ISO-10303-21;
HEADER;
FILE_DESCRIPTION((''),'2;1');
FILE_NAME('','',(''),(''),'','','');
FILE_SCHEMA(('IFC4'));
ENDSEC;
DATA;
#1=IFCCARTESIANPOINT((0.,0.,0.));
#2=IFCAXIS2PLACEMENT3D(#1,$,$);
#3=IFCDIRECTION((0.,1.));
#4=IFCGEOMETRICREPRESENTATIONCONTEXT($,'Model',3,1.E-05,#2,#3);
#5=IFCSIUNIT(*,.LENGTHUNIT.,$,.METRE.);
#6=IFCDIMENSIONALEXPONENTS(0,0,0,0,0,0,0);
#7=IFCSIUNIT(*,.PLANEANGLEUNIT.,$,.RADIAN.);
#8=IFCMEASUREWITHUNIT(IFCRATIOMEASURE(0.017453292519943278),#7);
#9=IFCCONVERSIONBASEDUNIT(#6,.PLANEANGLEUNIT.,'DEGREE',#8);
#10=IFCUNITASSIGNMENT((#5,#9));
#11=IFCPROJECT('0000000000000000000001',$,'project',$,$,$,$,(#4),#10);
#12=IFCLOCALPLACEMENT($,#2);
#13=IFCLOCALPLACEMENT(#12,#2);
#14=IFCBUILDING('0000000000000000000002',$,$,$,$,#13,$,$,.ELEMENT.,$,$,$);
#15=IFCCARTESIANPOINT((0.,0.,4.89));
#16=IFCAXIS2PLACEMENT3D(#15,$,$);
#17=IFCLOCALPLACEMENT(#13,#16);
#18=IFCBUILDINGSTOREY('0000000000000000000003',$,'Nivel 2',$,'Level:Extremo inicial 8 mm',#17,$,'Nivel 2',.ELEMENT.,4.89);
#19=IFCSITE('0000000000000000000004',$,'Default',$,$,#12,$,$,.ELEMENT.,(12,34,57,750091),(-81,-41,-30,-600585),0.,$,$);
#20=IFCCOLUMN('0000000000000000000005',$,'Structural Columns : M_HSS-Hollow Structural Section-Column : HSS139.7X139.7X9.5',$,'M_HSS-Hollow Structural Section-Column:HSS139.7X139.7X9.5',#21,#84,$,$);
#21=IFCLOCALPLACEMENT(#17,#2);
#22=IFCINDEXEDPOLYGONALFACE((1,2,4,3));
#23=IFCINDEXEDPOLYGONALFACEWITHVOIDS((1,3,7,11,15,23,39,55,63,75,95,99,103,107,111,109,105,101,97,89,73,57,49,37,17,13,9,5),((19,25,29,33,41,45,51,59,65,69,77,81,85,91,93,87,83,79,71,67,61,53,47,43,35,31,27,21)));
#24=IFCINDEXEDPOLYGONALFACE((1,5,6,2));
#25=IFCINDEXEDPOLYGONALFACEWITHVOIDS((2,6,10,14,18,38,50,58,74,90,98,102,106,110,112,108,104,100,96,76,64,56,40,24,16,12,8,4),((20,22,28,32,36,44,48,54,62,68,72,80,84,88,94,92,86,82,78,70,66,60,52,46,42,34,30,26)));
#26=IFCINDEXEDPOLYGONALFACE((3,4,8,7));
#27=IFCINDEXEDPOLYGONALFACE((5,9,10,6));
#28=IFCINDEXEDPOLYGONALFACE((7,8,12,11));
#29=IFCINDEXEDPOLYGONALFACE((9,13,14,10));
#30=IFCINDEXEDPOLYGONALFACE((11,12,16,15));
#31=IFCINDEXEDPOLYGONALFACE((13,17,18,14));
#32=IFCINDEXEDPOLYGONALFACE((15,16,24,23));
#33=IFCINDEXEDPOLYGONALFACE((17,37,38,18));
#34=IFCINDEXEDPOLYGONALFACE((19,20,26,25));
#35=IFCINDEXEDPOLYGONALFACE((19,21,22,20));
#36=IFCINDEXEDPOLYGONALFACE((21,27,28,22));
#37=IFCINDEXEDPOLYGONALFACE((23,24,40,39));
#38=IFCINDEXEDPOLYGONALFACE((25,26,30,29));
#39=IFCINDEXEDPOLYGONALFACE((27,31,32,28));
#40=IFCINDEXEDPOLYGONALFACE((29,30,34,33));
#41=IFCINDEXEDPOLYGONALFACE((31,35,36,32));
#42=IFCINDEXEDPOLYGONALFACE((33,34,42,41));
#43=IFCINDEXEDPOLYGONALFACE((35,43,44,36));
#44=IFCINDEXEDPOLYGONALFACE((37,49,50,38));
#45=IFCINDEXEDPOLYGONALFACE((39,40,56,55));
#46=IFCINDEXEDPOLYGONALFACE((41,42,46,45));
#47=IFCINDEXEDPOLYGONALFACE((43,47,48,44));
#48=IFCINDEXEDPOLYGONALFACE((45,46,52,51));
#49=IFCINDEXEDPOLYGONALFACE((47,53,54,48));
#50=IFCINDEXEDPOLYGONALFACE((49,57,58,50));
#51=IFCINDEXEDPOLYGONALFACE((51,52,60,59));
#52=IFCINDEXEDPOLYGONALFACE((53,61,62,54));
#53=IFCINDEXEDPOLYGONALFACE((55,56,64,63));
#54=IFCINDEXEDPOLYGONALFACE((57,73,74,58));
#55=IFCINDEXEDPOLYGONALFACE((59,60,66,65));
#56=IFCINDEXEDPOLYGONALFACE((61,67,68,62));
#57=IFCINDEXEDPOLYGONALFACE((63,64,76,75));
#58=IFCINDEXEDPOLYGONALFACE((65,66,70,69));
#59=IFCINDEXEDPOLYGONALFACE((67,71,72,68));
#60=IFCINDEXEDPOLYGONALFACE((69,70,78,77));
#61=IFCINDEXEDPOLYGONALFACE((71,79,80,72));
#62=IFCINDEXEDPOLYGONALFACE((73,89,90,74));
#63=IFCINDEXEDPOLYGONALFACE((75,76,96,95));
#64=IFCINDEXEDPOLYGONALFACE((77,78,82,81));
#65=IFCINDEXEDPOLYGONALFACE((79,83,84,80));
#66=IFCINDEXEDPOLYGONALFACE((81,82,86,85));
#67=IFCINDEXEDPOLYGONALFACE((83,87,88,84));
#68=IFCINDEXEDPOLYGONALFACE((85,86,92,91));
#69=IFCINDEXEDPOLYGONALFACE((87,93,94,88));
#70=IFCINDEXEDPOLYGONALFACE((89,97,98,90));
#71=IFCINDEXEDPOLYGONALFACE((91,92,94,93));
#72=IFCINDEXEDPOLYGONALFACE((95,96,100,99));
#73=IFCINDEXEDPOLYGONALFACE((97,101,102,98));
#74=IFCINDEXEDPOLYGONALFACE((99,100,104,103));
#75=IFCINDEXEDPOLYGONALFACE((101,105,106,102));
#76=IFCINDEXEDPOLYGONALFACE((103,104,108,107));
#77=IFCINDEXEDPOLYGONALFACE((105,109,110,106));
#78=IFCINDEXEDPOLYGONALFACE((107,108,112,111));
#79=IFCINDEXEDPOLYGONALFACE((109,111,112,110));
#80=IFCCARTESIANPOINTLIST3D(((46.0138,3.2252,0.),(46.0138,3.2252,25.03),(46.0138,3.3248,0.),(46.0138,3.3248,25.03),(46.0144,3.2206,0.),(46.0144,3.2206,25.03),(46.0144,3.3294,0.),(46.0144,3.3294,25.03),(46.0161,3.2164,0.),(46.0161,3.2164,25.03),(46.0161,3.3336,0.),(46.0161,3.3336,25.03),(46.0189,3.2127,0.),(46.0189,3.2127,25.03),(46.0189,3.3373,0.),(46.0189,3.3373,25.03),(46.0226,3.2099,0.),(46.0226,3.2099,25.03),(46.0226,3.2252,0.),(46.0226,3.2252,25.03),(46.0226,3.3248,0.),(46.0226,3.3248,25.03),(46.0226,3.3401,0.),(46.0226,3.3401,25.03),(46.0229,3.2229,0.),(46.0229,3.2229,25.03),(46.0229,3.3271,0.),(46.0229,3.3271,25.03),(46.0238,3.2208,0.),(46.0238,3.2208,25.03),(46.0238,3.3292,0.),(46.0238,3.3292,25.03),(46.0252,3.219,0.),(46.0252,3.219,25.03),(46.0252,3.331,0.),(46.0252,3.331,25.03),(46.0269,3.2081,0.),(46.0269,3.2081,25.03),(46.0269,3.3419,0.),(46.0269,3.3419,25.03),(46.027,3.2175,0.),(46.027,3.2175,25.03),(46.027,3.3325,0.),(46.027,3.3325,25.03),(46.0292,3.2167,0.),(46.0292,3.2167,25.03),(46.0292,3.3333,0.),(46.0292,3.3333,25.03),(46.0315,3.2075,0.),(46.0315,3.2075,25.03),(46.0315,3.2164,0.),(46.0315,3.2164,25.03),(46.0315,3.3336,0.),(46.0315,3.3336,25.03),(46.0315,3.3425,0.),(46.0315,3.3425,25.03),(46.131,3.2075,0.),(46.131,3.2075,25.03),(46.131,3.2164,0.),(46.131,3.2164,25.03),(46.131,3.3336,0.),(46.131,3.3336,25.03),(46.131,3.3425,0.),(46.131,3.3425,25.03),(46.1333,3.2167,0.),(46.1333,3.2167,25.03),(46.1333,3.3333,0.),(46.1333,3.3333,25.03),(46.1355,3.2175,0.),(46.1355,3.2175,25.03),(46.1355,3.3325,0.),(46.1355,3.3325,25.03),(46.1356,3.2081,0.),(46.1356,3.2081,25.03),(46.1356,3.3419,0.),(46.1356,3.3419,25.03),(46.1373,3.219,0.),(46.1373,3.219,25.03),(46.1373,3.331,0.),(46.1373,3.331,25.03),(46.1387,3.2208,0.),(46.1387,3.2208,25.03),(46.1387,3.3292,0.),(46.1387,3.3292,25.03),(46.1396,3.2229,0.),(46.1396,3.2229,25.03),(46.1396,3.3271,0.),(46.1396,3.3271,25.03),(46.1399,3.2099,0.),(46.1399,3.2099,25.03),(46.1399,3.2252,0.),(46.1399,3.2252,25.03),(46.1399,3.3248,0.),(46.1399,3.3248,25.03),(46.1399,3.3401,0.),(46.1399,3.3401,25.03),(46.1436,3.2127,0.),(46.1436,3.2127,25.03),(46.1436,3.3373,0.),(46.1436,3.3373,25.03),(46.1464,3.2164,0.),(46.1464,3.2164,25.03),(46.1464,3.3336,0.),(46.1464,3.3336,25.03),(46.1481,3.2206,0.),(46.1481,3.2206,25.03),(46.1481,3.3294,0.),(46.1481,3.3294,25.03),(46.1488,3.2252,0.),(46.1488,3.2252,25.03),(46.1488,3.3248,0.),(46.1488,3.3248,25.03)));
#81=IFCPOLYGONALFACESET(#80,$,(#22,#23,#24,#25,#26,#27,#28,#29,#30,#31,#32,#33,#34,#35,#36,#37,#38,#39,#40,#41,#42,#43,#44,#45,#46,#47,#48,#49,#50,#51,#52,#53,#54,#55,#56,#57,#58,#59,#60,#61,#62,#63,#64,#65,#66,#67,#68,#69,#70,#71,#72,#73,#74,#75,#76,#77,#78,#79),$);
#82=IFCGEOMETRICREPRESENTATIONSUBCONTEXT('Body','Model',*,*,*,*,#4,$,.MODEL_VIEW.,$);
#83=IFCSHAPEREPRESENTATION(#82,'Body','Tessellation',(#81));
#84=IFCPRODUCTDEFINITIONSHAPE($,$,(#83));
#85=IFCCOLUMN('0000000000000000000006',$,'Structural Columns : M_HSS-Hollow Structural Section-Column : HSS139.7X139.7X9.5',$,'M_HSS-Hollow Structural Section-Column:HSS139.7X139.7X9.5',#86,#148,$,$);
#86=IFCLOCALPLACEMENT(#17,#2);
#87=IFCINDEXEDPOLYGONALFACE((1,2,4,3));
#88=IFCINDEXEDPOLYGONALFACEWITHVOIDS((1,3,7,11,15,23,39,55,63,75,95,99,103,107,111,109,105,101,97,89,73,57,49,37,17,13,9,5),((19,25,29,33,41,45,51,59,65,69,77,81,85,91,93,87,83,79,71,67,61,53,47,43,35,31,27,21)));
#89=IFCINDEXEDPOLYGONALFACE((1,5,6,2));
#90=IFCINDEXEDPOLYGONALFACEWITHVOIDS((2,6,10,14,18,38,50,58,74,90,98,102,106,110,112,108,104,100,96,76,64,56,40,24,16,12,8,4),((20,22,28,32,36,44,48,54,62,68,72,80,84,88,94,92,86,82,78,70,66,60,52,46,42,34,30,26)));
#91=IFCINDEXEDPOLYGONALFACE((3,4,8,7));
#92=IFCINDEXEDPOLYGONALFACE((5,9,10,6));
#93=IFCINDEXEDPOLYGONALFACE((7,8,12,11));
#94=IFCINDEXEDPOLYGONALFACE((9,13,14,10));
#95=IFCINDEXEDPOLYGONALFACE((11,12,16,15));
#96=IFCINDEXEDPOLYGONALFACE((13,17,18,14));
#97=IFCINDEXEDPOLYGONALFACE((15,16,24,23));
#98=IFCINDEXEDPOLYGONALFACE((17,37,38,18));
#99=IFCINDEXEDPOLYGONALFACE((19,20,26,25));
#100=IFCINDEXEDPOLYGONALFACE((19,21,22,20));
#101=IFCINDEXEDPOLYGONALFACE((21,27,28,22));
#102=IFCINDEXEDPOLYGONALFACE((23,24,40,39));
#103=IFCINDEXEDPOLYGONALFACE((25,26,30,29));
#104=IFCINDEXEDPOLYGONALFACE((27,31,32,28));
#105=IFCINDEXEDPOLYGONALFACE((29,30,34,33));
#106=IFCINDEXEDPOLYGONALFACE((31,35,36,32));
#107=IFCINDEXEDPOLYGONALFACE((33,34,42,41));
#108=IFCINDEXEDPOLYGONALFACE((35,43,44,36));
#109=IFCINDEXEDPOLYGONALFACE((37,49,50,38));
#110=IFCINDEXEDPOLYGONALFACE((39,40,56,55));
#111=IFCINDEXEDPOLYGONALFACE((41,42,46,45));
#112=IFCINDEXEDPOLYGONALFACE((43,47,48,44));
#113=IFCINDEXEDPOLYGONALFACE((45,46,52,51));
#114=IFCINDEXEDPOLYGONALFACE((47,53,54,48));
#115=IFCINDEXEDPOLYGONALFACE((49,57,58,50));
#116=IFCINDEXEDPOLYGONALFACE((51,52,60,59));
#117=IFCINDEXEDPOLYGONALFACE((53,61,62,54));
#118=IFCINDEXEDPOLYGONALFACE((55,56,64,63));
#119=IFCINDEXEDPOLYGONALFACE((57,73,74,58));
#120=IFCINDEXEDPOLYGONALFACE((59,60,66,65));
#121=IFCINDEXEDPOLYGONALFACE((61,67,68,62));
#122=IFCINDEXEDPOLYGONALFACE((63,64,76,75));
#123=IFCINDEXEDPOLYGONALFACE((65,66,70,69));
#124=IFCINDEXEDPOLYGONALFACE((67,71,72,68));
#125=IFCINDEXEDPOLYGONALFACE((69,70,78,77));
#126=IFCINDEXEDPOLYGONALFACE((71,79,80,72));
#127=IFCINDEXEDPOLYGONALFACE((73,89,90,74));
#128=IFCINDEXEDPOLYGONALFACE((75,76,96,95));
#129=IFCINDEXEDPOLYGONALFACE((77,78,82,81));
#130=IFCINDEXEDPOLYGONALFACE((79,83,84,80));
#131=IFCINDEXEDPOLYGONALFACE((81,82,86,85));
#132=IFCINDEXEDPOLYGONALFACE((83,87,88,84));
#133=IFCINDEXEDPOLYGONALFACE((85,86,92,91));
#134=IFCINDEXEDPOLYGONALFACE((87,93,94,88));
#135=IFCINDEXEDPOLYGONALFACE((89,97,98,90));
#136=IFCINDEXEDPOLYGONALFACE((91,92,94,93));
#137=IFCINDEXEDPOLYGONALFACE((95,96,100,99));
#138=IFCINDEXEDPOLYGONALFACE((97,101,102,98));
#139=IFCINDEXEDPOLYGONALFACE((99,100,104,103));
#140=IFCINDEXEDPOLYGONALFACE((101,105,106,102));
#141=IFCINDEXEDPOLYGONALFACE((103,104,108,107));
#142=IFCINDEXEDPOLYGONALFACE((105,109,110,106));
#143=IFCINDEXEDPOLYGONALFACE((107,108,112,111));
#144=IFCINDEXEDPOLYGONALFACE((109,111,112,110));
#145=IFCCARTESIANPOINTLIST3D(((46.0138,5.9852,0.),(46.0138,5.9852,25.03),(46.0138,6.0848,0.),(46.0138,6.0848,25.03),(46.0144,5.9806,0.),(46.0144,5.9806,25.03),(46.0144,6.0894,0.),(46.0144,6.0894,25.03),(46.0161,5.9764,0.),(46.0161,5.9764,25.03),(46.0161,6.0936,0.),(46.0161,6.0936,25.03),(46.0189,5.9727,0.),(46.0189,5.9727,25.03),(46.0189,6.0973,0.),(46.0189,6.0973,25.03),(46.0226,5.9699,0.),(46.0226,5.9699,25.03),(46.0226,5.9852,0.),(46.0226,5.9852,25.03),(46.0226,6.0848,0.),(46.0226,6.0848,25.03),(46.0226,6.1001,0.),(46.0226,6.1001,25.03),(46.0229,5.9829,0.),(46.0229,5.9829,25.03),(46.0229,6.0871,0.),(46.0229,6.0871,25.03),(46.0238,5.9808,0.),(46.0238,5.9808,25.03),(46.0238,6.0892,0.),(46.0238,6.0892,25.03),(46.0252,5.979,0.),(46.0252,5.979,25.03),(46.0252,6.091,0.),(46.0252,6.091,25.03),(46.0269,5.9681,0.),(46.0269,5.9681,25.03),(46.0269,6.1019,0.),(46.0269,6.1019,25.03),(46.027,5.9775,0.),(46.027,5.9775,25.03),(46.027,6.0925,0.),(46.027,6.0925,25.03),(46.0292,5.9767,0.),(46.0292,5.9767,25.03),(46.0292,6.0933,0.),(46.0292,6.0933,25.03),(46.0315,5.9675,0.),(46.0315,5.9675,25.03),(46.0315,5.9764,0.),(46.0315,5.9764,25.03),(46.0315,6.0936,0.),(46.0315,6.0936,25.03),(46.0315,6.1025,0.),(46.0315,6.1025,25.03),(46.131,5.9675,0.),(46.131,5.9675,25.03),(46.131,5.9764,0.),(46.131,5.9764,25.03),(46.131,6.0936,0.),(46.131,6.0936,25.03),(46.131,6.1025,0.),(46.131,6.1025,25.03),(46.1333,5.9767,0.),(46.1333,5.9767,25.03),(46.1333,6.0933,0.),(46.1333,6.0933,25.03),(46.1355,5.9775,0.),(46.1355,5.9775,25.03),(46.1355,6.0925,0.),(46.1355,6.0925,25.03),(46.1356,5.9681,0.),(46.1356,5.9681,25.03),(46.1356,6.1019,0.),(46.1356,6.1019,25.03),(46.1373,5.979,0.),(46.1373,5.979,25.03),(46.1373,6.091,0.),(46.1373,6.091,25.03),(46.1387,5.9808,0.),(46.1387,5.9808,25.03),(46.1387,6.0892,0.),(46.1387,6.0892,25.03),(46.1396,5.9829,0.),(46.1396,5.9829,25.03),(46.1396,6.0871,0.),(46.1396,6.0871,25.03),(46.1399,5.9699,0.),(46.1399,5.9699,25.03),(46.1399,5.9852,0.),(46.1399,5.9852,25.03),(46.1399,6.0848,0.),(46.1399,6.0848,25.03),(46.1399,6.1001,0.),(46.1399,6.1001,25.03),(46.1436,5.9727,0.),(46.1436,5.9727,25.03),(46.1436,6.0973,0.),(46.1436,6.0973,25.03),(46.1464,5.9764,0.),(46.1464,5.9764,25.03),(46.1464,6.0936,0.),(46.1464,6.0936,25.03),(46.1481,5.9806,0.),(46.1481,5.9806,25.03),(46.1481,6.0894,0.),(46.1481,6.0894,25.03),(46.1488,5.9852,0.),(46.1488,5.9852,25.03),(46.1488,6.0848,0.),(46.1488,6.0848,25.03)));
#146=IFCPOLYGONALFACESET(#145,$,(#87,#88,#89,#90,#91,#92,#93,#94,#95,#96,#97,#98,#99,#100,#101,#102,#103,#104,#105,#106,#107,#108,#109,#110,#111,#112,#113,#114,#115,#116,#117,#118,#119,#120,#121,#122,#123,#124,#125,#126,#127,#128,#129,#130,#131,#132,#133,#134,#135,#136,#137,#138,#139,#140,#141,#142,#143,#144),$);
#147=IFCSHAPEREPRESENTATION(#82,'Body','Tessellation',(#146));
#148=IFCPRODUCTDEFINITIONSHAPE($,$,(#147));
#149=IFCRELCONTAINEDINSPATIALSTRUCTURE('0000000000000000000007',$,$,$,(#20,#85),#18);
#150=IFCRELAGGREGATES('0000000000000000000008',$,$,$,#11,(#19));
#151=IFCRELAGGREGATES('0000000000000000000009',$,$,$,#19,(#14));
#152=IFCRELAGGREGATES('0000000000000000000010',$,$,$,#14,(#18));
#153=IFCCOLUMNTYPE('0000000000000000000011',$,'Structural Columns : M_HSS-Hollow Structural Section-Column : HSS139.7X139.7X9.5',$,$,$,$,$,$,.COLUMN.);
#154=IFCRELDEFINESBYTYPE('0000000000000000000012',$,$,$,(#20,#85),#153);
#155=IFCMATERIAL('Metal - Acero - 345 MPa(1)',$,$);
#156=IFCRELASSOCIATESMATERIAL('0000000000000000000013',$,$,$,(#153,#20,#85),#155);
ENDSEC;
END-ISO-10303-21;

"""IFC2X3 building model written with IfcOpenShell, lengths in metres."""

from ifc_helpers import new_model, entity, si_unit, converted_unit, direction, frame, frame_2d, origin, place, context, subcontext, project, spatial, polyline, circle_curve, parameter, trimmed, segment, composite_curve, outline, extrude, source, transform, mapped, material, type_object, type_shapes, element, save


model = new_model("IFC2X3")

# Units and contexts
model_context = context("Model", 3, precision=1e-05, world=origin(), true_north=direction((0.0, 1.0)))
body_context = subcontext(model_context, "Body", "Model", "MODEL_VIEW")
ifc_project = project(units=[si_unit("LENGTHUNIT", "METRE"), converted_unit("PLANEANGLEUNIT", "DEGREE", entity("IfcRatioMeasure", 0.017453292519943278), si_unit("PLANEANGLEUNIT", "RADIAN"), dimensions=[0, 0, 0, 0, 0, 0, 0])], contexts=[model_context])

# Site, building, storey
site_placement = place(None, origin())
site = spatial("IfcSite", under=ifc_project, at=site_placement, Name="Default", CompositionType="ELEMENT", RefLatitude=(12, 34, 57, 750091), RefLongitude=(-81, -41, -30, -600585), RefElevation=0.0)
building_placement = place(site_placement, origin())
building = spatial("IfcBuilding", under=site, at=building_placement, CompositionType="ELEMENT")
storey_placement = place(building_placement, frame((0.0, 0.0, 4.89)))
storey = spatial("IfcBuildingStorey", under=building, at=storey_placement, Name="Nivel 2", ObjectType="Level:Extremo inicial 8 mm", LongName="Nivel 2", CompositionType="ELEMENT", Elevation=4.89)

# Columns
ifc_material_1 = material(Name="Metal - Acero - 345 MPa(1)")
column_type_1 = type_object("IfcColumnType", Name="Structural Columns : M_HSS-Hollow Structural Section-Column : HSS139.7X139.7X9.5", PredefinedType="COLUMN", material=ifc_material_1)
shared_shape_1 = source(origin(), body_context, "Body", "SweptSolid", [
    extrude(outline(composite_curve([segment(polyline([(-0.0498, -0.0675), (0.0498, -0.0675)]), True, "CONTINUOUS"), segment(trimmed(circle_curve(frame_2d((0.0498, -0.0498), x_axis=(-1.0, 0.0)), 0.0177), [parameter(90.0)], [parameter(180.0)], True, "PARAMETER"), True, "CONTINUOUS"), segment(polyline([(0.0675, -0.0498), (0.0675, 0.0498)]), True, "CONTINUOUS"), segment(trimmed(circle_curve(frame_2d((0.0498, 0.0498), x_axis=(-1.0, 0.0)), 0.0177), [parameter(180.0)], [parameter(270.0)], True, "PARAMETER"), True, "CONTINUOUS"), segment(polyline([(0.0498, 0.0675), (-0.0498, 0.0675)]), True, "CONTINUOUS"), segment(trimmed(circle_curve(frame_2d((-0.0498, 0.0498), x_axis=(-1.0, 0.0)), 0.0177), [parameter(270.0)], [parameter(360.0)], True, "PARAMETER"), True, "CONTINUOUS"), segment(polyline([(-0.0675, 0.0498), (-0.0675, -0.0498)]), True, "CONTINUOUS"), segment(trimmed(circle_curve(frame_2d((-0.0498, -0.0498), x_axis=(-1.0, 0.0)), 0.0177), [parameter(360.0)], [parameter(90.0)], True, "PARAMETER"), True, "CONTINUOUS")], self_intersect=False), holes=[composite_curve([segment(trimmed(circle_curve(frame_2d((-0.0498, -0.0498), x_axis=(-1.0, 0.0)), 0.0089), [parameter(0.0)], [parameter(90.0)], True, "PARAMETER"), False, "CONTINUOUS"), segment(polyline([(-0.0586, -0.0498), (-0.0586, 0.0498)]), True, "CONTINUOUS"), segment(trimmed(circle_curve(frame_2d((-0.0498, 0.0498), x_axis=(-1.0, 0.0)), 0.0089), [parameter(270.0)], [parameter(0.0)], True, "PARAMETER"), False, "CONTINUOUS"), segment(polyline([(-0.0498, 0.0586), (0.0498, 0.0586)]), True, "CONTINUOUS"), segment(trimmed(circle_curve(frame_2d((0.0498, 0.0498), x_axis=(-1.0, 0.0)), 0.0089), [parameter(180.0)], [parameter(270.0)], True, "PARAMETER"), False, "CONTINUOUS"), segment(polyline([(0.0586, 0.0498), (0.0586, -0.0498)]), True, "CONTINUOUS"), segment(trimmed(circle_curve(frame_2d((0.0498, -0.0498), x_axis=(-1.0, 0.0)), 0.0089), [parameter(90.0)], [parameter(180.0)], True, "PARAMETER"), False, "CONTINUOUS"), segment(polyline([(0.0498, -0.0586), (-0.0498, -0.0586)]), True, "CONTINUOUS")], self_intersect=False)]), frame((0.0, 0.0, 4.89), z_axis=(0.0, 0.0, 1.0), x_axis=(-1.0, 0.0, 0.0)), (0.0, 0.0, 1.0), 25.03),
])
type_shapes(column_type_1, [shared_shape_1])
for number, where, name in (
    (1, (46.0813, 3.275, -4.89), "Structural Columns : M_HSS-Hollow Structural Section-Column : HSS139.7X139.7X9.5"),
    (2, (46.0813, 6.035, -4.89), "Structural Columns : M_HSS-Hollow Structural Section-Column : HSS139.7X139.7X9.5"),
):
    element("IfcColumn", number, at=place(storey_placement, frame(where)), inside=storey, type_object=column_type_1, material=ifc_material_1, Name=name, ObjectType="M_HSS-Hollow Structural Section-Column:HSS139.7X139.7X9.5", context=body_context, shape_type="MappedRepresentation", body=[
        mapped(shared_shape_1, transform((0.0, 0.0, 0.0), scale=1.0)),
    ])

save(model, "model.ifc")
